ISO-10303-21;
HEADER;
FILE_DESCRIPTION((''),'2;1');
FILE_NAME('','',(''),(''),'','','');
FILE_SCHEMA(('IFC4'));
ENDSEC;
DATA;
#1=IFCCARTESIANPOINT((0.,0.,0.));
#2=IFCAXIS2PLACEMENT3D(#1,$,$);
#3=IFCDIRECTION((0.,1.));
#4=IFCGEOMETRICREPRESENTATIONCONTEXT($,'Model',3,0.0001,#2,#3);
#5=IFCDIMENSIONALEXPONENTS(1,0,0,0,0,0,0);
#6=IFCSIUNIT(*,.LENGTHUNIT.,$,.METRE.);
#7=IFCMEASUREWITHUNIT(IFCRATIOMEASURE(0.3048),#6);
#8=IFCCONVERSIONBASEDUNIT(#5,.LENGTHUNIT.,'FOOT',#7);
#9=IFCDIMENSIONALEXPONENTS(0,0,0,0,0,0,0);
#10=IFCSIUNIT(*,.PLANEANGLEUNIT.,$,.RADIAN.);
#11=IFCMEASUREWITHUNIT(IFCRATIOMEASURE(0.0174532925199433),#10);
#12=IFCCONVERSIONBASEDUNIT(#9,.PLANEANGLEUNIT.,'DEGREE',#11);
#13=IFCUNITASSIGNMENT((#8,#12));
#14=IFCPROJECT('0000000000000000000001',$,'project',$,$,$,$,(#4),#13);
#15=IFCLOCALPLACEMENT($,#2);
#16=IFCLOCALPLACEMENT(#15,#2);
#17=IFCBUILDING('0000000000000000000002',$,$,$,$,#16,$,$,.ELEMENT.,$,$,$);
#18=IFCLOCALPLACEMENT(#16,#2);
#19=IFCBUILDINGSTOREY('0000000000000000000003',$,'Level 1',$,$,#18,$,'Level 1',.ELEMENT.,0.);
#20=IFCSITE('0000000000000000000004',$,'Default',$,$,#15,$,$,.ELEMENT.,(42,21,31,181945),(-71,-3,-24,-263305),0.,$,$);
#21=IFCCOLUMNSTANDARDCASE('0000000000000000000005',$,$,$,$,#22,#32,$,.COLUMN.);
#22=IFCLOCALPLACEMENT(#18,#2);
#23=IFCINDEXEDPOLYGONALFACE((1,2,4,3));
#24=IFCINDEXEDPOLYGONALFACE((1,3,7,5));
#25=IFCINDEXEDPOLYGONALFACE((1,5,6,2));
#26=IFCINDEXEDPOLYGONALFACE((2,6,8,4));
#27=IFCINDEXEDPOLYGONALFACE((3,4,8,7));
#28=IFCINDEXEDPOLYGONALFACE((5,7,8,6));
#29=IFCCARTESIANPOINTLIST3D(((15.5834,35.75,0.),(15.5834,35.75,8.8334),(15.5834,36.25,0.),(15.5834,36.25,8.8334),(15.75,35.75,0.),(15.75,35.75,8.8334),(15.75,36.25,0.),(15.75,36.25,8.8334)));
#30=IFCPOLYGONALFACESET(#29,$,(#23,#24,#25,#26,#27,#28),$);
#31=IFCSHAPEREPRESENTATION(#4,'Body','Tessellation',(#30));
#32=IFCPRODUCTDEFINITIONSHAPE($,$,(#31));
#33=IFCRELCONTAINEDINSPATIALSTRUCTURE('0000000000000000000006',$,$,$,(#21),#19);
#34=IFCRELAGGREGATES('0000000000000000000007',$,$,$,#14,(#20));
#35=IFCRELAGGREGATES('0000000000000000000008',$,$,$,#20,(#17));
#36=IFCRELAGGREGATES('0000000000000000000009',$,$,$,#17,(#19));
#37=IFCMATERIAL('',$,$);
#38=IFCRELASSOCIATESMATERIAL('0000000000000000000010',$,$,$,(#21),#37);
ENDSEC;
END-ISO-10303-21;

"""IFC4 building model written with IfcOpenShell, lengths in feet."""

from ifc_helpers import new_model, entity, si_unit, converted_unit, direction, frame, origin, place, context, project, spatial, rectangle, extrude, material, element, save


model = new_model("IFC4")

# Units and contexts
model_context = context("Model", 3, precision=0.0001, world=origin(), true_north=direction((0.0, 1.0)))
ifc_project = project(units=[converted_unit("LENGTHUNIT", "FOOT", entity("IfcRatioMeasure", 0.3048), si_unit("LENGTHUNIT", "METRE"), dimensions=[1, 0, 0, 0, 0, 0, 0]), converted_unit("PLANEANGLEUNIT", "DEGREE", entity("IfcRatioMeasure", 0.0174532925199433), si_unit("PLANEANGLEUNIT", "RADIAN"), dimensions=[0, 0, 0, 0, 0, 0, 0])], contexts=[model_context])

# Site, building, storey
site_placement = place(None, origin())
site = spatial("IfcSite", under=ifc_project, at=site_placement, Name="Default", CompositionType="ELEMENT", RefLatitude=(42, 21, 31, 181945), RefLongitude=(-71, -3, -24, -263305), RefElevation=0.0)
building_placement = place(site_placement, origin())
building = spatial("IfcBuilding", under=site, at=building_placement, CompositionType="ELEMENT")
storey_placement = place(building_placement, origin())
storey = spatial("IfcBuildingStorey", under=building, at=storey_placement, Name="Level 1", LongName="Level 1", CompositionType="ELEMENT", Elevation=0.0)

# Column
ifc_material_1 = material(Name="")
placement_1 = place(storey_placement, frame((0.25, 36.0, 0.0)))
column_1_placement = place(placement_1, frame((15.4167, 0.0, 0.0), z_axis=(0.0, 0.0, 1.0), x_axis=(1.0, 0.0, 0.0)))
element("IfcColumnStandardCase", 1, at=column_1_placement, inside=storey, material=ifc_material_1, PredefinedType="COLUMN", context=model_context, shape_type="SweptSolid", body=[
    extrude(rectangle(XDim=0.1667, YDim=0.5), origin(), (0.0, 0.0, 1.0), 8.8334),
])

save(model, "model.ifc")
